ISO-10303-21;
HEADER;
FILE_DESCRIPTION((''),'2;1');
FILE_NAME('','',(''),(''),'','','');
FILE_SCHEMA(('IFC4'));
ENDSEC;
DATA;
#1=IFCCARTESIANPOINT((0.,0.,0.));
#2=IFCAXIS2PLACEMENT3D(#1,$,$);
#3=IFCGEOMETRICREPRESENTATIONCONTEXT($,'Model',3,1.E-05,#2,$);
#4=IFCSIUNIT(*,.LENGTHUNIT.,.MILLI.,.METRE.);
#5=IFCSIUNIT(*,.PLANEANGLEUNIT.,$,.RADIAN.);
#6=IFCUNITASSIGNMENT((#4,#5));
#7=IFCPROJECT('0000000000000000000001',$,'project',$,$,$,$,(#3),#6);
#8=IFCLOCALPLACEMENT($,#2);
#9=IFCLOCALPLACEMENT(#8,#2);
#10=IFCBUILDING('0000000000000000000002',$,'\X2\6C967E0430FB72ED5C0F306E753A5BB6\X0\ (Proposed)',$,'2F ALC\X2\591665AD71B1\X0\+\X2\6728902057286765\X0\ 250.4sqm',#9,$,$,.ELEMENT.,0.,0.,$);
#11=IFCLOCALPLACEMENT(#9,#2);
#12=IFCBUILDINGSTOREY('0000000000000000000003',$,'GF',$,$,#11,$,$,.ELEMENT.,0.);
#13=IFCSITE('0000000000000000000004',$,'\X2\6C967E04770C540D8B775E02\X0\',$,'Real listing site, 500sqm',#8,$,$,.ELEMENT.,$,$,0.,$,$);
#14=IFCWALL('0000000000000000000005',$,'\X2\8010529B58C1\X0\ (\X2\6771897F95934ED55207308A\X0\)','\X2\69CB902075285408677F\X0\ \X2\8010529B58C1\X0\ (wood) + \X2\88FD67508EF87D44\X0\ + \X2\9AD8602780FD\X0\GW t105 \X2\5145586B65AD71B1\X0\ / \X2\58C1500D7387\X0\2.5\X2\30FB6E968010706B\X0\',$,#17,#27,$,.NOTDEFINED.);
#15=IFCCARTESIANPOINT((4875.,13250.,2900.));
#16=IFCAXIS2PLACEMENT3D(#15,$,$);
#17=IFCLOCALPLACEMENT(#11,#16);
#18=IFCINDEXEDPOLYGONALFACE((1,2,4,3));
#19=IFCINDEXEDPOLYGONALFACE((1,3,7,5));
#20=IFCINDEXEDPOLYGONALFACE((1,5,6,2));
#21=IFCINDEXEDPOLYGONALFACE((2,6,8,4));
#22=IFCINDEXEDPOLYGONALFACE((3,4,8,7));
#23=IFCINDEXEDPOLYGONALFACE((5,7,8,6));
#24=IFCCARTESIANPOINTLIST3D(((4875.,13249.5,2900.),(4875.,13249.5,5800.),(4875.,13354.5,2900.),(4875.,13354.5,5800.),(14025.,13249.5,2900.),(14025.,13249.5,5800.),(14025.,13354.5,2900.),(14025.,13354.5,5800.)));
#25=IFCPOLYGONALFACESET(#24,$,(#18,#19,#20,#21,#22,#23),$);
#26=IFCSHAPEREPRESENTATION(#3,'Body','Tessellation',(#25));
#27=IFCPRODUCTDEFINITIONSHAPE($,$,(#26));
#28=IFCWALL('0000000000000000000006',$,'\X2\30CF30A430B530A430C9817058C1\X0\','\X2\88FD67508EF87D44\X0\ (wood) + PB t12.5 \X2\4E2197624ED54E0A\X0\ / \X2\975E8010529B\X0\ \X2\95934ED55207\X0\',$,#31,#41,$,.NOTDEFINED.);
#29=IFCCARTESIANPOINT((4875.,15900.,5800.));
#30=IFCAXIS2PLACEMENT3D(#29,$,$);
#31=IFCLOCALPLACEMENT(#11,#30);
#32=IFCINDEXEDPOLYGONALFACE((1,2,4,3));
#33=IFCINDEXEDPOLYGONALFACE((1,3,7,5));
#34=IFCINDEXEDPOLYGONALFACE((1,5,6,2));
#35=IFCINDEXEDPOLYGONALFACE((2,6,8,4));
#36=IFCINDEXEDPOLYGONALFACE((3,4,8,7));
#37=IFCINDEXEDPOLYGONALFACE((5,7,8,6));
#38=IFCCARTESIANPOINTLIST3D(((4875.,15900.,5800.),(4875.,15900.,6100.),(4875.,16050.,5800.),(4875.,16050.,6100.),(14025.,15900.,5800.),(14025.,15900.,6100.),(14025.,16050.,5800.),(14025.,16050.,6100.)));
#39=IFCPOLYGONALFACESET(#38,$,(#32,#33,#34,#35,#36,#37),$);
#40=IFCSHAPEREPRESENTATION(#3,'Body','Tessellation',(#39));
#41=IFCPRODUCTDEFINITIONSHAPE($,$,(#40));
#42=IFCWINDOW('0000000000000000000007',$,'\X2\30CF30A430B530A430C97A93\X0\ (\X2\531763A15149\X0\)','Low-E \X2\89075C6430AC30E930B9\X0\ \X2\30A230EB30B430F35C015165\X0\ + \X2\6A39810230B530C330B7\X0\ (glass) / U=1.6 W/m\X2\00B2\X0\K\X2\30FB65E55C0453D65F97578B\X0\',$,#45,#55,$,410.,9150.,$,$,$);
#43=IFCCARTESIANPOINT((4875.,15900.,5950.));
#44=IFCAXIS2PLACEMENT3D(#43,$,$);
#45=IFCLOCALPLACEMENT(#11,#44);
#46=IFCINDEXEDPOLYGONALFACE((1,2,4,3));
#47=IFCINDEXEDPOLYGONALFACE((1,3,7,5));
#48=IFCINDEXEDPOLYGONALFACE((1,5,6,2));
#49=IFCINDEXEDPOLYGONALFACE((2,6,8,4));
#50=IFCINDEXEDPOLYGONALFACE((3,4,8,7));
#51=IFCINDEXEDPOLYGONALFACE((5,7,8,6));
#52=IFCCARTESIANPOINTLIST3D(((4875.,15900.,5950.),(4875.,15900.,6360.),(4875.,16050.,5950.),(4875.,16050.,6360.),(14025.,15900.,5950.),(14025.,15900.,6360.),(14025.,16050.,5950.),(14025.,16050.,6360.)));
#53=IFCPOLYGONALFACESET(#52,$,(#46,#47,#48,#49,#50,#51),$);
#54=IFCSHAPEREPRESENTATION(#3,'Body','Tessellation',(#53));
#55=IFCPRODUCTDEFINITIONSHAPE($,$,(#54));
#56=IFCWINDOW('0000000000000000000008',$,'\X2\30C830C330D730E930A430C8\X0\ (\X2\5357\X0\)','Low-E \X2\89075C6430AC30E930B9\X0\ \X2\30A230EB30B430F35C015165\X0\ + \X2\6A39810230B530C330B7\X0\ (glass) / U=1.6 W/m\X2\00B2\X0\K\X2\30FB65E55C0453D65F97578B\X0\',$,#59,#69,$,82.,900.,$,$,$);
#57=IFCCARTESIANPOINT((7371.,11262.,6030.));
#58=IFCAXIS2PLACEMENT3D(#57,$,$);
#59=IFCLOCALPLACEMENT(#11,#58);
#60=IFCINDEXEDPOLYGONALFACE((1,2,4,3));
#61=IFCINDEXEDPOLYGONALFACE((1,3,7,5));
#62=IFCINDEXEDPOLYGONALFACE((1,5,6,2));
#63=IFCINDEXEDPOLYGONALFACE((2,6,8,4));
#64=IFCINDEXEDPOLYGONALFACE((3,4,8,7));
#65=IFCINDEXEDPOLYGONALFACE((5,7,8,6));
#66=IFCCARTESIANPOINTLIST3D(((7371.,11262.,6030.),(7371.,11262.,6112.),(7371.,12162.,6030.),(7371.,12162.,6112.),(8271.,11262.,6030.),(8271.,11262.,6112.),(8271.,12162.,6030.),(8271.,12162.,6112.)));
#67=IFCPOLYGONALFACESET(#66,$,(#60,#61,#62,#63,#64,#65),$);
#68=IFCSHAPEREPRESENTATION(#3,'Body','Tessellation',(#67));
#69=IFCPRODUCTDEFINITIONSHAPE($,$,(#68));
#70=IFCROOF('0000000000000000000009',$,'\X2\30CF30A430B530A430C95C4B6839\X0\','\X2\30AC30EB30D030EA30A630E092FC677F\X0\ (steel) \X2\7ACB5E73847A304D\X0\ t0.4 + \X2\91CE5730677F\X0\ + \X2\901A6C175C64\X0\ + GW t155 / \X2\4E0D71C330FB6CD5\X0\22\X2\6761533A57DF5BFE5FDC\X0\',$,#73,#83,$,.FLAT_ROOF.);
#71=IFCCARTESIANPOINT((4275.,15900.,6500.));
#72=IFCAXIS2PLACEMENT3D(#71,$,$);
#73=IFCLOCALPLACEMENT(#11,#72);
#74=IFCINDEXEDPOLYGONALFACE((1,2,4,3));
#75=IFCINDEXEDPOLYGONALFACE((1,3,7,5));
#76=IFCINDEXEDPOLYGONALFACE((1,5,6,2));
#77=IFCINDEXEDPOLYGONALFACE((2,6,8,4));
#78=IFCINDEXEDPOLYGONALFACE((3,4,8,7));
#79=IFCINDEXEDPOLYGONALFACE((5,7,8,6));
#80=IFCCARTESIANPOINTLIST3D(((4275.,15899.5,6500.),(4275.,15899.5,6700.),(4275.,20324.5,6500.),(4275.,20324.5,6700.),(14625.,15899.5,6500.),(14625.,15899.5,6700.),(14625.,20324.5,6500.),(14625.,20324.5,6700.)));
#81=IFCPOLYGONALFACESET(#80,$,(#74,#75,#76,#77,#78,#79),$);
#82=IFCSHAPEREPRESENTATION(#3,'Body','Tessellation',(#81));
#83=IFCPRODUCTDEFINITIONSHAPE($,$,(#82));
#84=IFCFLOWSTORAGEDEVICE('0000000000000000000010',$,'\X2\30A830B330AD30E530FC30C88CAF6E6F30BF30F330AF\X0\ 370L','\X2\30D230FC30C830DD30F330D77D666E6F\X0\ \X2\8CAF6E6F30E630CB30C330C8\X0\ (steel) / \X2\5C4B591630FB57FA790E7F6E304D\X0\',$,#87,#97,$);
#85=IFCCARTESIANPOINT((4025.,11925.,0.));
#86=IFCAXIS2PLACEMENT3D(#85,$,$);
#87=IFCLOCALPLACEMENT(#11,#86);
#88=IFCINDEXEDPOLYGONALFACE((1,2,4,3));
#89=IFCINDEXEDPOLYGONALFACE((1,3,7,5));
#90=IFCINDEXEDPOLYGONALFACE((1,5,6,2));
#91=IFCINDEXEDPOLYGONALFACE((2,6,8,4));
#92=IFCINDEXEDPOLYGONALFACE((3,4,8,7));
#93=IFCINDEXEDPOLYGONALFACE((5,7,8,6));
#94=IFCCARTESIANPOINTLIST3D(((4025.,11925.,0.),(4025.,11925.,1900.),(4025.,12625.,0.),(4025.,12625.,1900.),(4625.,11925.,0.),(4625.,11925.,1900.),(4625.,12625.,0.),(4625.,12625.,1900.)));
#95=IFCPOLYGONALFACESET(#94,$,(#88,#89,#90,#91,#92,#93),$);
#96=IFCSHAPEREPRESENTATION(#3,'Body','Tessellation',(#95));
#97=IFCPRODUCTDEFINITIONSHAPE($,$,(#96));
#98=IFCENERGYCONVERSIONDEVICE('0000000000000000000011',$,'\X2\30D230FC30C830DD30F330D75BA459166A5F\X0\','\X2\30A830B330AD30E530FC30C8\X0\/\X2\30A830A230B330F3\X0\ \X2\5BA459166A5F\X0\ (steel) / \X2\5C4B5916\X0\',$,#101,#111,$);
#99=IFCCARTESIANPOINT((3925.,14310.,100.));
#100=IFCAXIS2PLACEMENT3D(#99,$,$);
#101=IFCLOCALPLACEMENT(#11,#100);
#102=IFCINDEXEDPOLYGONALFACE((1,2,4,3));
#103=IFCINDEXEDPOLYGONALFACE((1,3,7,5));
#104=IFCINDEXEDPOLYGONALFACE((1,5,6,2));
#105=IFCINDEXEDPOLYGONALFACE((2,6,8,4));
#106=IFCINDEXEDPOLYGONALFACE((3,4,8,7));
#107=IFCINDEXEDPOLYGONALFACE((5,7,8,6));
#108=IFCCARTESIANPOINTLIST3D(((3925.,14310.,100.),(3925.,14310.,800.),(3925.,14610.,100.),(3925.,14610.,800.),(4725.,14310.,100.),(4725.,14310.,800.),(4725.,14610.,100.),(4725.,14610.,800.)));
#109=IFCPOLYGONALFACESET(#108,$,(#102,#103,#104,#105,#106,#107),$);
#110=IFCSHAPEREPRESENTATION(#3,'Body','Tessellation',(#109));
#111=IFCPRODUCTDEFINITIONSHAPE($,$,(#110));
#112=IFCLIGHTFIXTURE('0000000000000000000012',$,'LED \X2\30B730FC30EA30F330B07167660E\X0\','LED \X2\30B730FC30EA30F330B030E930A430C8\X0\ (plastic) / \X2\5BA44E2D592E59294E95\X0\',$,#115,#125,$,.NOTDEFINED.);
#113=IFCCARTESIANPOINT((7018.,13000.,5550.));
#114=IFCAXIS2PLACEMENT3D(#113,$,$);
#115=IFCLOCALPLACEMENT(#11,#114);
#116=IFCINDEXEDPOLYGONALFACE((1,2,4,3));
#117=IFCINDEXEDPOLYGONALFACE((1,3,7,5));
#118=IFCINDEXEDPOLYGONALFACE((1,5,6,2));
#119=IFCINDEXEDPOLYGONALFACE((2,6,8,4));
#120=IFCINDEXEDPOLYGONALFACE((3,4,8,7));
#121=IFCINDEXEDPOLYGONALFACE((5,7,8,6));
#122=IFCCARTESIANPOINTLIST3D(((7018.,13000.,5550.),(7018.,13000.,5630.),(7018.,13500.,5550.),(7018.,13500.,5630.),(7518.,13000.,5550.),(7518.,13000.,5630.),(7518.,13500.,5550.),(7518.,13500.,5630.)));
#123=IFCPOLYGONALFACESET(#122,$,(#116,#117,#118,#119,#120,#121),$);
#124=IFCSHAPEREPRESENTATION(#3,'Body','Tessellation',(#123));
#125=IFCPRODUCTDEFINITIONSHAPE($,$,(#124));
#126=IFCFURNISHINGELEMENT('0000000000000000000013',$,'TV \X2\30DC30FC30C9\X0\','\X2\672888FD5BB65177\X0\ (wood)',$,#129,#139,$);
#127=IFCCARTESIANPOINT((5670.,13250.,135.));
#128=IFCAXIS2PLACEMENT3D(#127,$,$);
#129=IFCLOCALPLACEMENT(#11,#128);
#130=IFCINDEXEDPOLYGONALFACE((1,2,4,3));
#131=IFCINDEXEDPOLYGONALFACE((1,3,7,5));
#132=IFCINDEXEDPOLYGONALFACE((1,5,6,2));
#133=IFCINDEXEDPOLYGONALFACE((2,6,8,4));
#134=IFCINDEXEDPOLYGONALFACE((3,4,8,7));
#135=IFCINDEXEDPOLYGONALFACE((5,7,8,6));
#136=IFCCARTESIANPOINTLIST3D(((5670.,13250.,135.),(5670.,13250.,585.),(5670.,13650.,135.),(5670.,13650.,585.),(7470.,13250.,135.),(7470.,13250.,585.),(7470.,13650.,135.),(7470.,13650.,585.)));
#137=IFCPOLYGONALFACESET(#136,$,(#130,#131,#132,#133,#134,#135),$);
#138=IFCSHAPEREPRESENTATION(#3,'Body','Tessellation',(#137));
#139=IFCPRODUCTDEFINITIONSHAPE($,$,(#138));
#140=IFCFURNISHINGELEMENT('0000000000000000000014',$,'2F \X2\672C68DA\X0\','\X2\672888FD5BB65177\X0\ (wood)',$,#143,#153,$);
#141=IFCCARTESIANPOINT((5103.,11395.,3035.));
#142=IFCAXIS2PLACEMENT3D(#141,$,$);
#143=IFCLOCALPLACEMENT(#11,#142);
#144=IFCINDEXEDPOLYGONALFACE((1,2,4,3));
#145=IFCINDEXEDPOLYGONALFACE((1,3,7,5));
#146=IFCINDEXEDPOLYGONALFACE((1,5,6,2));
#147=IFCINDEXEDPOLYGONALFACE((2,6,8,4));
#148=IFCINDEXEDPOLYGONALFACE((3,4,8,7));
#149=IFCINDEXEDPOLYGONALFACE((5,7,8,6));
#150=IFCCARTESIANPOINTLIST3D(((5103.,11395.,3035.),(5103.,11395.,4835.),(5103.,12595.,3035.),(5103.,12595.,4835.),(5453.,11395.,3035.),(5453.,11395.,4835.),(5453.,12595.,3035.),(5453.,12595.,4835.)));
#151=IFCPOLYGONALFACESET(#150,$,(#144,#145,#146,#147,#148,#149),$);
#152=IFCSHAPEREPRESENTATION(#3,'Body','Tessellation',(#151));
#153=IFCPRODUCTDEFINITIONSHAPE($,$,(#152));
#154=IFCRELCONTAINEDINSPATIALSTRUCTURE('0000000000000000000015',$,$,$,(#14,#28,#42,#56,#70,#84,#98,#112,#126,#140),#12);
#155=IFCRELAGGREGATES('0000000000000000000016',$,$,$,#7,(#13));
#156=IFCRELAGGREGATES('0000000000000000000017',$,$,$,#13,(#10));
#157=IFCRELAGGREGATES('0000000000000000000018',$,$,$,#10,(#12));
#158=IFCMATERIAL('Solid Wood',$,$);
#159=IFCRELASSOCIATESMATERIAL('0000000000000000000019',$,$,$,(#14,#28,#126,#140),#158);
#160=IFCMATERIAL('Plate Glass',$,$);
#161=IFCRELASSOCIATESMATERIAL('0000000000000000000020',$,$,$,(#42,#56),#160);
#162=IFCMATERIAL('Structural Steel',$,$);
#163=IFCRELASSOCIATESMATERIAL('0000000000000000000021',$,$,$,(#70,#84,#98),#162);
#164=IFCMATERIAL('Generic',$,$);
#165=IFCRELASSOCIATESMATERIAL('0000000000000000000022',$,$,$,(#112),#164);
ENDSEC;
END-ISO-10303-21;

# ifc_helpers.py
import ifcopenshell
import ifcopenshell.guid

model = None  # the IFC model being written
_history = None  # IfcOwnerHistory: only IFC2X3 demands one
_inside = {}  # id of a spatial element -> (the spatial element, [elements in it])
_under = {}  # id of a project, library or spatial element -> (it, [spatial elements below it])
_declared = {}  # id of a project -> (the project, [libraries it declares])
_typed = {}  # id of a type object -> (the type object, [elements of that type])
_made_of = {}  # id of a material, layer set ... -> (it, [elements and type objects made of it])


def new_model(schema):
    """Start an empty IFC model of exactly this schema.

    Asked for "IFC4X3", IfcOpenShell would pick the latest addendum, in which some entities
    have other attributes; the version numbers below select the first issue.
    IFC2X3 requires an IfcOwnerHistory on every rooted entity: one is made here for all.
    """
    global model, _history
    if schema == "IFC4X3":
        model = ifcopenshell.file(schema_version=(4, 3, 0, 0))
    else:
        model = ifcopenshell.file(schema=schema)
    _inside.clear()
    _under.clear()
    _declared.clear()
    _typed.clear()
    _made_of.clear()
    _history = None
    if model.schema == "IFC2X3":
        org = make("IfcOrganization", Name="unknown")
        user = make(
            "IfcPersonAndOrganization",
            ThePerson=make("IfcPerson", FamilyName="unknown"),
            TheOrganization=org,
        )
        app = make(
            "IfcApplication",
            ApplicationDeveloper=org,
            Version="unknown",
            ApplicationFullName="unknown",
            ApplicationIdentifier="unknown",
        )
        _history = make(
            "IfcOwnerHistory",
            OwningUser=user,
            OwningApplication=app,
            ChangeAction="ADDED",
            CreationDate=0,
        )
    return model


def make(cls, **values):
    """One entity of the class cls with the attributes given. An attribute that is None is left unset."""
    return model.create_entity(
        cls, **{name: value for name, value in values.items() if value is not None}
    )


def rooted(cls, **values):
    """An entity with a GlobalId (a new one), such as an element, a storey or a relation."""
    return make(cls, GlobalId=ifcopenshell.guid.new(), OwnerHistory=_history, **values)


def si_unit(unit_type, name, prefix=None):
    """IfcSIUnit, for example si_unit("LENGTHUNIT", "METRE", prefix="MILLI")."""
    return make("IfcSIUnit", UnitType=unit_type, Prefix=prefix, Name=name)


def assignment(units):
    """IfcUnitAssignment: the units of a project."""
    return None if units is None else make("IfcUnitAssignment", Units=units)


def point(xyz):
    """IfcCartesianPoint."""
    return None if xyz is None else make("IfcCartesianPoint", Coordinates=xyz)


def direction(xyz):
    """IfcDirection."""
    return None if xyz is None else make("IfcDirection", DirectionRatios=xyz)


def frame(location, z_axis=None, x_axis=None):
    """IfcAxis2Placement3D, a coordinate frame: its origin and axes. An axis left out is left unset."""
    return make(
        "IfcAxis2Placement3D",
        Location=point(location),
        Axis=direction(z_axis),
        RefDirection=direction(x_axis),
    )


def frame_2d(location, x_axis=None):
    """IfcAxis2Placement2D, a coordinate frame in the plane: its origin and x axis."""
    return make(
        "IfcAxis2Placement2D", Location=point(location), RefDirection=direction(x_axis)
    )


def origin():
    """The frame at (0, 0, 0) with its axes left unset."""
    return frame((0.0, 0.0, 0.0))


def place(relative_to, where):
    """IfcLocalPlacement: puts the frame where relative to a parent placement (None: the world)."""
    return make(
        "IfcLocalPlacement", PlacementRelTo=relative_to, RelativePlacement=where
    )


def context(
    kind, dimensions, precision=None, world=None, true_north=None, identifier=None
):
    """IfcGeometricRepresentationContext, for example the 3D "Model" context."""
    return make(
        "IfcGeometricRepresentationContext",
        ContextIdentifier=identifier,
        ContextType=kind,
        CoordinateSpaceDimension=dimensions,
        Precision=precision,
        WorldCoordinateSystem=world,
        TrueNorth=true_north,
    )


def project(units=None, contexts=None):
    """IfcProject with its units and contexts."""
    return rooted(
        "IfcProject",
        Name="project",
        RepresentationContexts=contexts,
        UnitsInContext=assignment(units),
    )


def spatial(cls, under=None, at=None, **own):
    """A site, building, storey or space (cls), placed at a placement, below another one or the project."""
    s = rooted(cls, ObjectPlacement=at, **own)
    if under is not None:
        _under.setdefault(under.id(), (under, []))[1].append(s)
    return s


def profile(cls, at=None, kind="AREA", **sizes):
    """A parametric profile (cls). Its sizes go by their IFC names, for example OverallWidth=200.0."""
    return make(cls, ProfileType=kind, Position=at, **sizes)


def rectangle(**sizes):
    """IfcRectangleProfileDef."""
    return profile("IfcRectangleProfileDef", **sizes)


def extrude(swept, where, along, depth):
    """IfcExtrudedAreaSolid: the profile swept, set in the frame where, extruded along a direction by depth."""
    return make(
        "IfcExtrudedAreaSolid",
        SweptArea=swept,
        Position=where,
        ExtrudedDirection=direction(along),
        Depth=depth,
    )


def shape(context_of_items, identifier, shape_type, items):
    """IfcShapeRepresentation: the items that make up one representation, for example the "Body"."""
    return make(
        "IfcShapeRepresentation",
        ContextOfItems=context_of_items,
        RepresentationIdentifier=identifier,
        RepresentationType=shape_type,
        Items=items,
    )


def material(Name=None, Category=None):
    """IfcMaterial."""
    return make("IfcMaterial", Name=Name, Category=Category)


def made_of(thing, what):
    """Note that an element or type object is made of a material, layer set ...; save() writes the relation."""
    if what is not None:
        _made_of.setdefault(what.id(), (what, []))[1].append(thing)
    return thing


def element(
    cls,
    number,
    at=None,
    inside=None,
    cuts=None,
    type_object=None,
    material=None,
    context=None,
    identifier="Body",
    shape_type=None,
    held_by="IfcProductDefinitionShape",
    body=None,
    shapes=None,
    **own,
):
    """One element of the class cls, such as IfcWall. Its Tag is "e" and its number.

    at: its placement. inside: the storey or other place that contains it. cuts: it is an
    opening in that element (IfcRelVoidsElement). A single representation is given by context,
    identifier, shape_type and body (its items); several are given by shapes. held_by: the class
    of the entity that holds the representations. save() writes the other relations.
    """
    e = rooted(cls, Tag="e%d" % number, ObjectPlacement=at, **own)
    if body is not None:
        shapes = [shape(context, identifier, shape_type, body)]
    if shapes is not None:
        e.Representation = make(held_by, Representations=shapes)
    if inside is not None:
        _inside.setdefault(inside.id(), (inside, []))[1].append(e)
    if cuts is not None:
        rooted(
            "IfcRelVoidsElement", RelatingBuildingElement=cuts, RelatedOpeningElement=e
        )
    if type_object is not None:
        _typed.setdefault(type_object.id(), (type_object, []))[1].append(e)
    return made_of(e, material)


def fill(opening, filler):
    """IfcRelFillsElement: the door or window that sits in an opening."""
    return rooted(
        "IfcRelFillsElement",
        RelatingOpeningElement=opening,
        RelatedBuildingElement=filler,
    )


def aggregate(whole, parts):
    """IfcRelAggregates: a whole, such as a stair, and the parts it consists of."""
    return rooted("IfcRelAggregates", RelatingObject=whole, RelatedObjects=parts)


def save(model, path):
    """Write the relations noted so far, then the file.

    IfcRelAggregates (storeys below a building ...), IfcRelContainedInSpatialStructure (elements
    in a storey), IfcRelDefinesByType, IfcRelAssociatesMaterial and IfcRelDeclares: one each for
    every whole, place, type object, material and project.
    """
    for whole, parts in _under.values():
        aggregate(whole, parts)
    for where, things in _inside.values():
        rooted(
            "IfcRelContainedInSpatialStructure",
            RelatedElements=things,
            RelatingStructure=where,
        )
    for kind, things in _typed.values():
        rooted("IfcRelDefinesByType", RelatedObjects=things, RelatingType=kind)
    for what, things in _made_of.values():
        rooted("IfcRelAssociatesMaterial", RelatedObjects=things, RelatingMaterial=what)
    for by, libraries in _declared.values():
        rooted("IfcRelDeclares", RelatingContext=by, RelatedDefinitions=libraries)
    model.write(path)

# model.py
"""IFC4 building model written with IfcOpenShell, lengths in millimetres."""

from ifc_helpers import new_model, si_unit, frame, frame_2d, origin, place, context, project, spatial, rectangle, extrude, material, element, fill, save


model = new_model("IFC4")

# Units and contexts
model_context = context("Model", 3, precision=1e-05, world=origin())
ifc_project = project(units=[si_unit("LENGTHUNIT", "METRE", prefix="MILLI"), si_unit("PLANEANGLEUNIT", "RADIAN")], contexts=[model_context])

# Site, building, storey
site_placement = place(None, origin())
site = spatial("IfcSite", under=ifc_project, at=site_placement, Name="沖縄県名護市", ObjectType="Real listing site, 500sqm", CompositionType="ELEMENT", RefElevation=0.0)
building_placement = place(site_placement, origin())
building = spatial("IfcBuilding", under=site, at=building_placement, Name="沖縄・狭小の町家 (Proposed)", ObjectType="2F ALC外断熱+木造在来 250.4sqm", CompositionType="ELEMENT", ElevationOfRefHeight=0.0, ElevationOfTerrain=0.0)
storey_placement = place(building_placement, origin())
storey = spatial("IfcBuildingStorey", under=building, at=storey_placement, Name="GF", CompositionType="ELEMENT", Elevation=0.0)

# Shared definitions
ifc_material_1 = material(Name="Solid Wood")

# Wall
wall_1_placement = place(storey_placement, frame((4875.0, 13250.0, 2900.0)))
element("IfcWall", 1, at=wall_1_placement, inside=storey, material=ifc_material_1, Name="耐力壁 (東西間仕切り)", Description="構造用合板 耐力壁 (wood) + 製材軸組 + 高性能GW t105 充填断熱 / 壁倍率2.5・準耐火", PredefinedType="NOTDEFINED", context=model_context, shape_type="SweptSolid", body=[
    extrude(rectangle(XDim=9150.0, YDim=105.0, at=frame_2d((4575.0, 52.0))), frame((4875.0, 13250.0, 2900.0)), (0.0, 0.0, 1.0), 2900.0),
])

# Wall, opening, window
wall_2_placement = place(storey_placement, frame((4875.0, 15900.0, 5800.0)))
wall_2 = element("IfcWall", 2, at=wall_2_placement, inside=storey, material=ifc_material_1, Name="ハイサイド腰壁", Description="製材軸組 (wood) + PB t12.5 両面仕上 / 非耐力 間仕切", PredefinedType="NOTDEFINED", context=model_context, shape_type="SweptSolid", body=[
    extrude(rectangle(XDim=9150.0, YDim=150.0, at=frame_2d((4575.0, 75.0))), frame((4875.0, 15900.0, 5800.0)), (0.0, 0.0, 1.0), 700.0),
])
opening_1_placement = place(storey_placement, frame((4875.0, 15900.0, 5950.0)))
opening_1 = element("IfcOpeningElement", 3, at=opening_1_placement, cuts=wall_2, PredefinedType="NOTDEFINED", context=model_context, shape_type="SweptSolid", body=[
    extrude(rectangle(XDim=9150.0, YDim=150.0, at=frame_2d((4575.0, 75.0))), frame((4875.0, 15900.0, 5950.0)), (0.0, 0.0, 1.0), 410.0),
])
ifc_material_2 = material(Name="Plate Glass")
window_1_placement = place(storey_placement, frame((4875.0, 15900.0, 5950.0)))
window_1 = element("IfcWindow", 4, at=window_1_placement, inside=storey, material=ifc_material_2, Name="ハイサイド窓 (北採光)", Description="Low-E 複層ガラス アルゴン封入 + 樹脂サッシ (glass) / U=1.6 W/m²K・日射取得型", OverallHeight=410.0, OverallWidth=9150.0, context=model_context, shape_type="SweptSolid", body=[
    extrude(rectangle(XDim=9150.0, YDim=150.0, at=frame_2d((4575.0, 75.0))), frame((4875.0, 15900.0, 5950.0)), (0.0, 0.0, 1.0), 410.0),
])
fill(opening_1, window_1)

# Window
window_2_placement = place(storey_placement, frame((7371.0, 11262.0, 6030.0)))
element("IfcWindow", 5, at=window_2_placement, inside=storey, material=ifc_material_2, Name="トップライト (南)", Description="Low-E 複層ガラス アルゴン封入 + 樹脂サッシ (glass) / U=1.6 W/m²K・日射取得型", OverallHeight=82.0, OverallWidth=900.0, context=model_context, shape_type="SweptSolid", body=[
    extrude(rectangle(XDim=900.0, YDim=900.0, at=frame_2d((450.0, 450.0))), frame((7371.0, 11262.0, 6030.0)), (0.0, 0.0, 1.0), 82.0),
])

# Roof
ifc_material_3 = material(Name="Structural Steel")
roof_placement = place(storey_placement, frame((4275.0, 15900.0, 6500.0)))
element("IfcRoof", 6, at=roof_placement, inside=storey, material=ifc_material_3, Name="ハイサイド屋根", Description="ガルバリウム鋼板 (steel) 立平葺き t0.4 + 野地板 + 通気層 + GW t155 / 不燃・法22条区域対応", PredefinedType="FLAT_ROOF", context=model_context, shape_type="SweptSolid", body=[
    extrude(rectangle(XDim=10350.0, YDim=4425.0, at=frame_2d((5175.0, 2212.0))), frame((4275.0, 15900.0, 6500.0)), (0.0, 0.0, 1.0), 200.0),
])

# Flow storage device
flow_storage_device_placement = place(storey_placement, frame((4025.0, 11925.0, 0.0)))
element("IfcFlowStorageDevice", 7, at=flow_storage_device_placement, inside=storey, material=ifc_material_3, Name="エコキュート貯湯タンク 370L", Description="ヒートポンプ給湯 貯湯ユニット (steel) / 屋外・基礎置き", context=model_context, shape_type="SweptSolid", body=[
    extrude(rectangle(XDim=600.0, YDim=700.0, at=frame_2d((300.0, 350.0))), frame((4025.0, 11925.0, 0.0)), (0.0, 0.0, 1.0), 1900.0),
])

# Energy conversion device
energy_conversion_device_placement = place(storey_placement, frame((3925.0, 14310.0, 100.0)))
element("IfcEnergyConversionDevice", 8, at=energy_conversion_device_placement, inside=storey, material=ifc_material_3, Name="ヒートポンプ室外機", Description="エコキュート/エアコン 室外機 (steel) / 屋外", context=model_context, shape_type="SweptSolid", body=[
    extrude(rectangle(XDim=800.0, YDim=300.0, at=frame_2d((400.0, 150.0))), frame((3925.0, 14310.0, 100.0)), (0.0, 0.0, 1.0), 700.0),
])

# Light fixture
ifc_material_4 = material(Name="Generic")
light_fixture_placement = place(storey_placement, frame((7018.0, 13000.0, 5550.0)))
element("IfcLightFixture", 9, at=light_fixture_placement, inside=storey, material=ifc_material_4, Name="LED シーリング照明", Description="LED シーリングライト (plastic) / 室中央天井", PredefinedType="NOTDEFINED", context=model_context, shape_type="SweptSolid", body=[
    extrude(rectangle(XDim=500.0, YDim=500.0, at=frame_2d((250.0, 250.0))), frame((7018.0, 13000.0, 5550.0)), (0.0, 0.0, 1.0), 80.0),
])

# Furnishing elements
furnishing_1_placement = place(storey_placement, frame((5670.0, 13250.0, 135.0)))
element("IfcFurnishingElement", 10, at=furnishing_1_placement, inside=storey, material=ifc_material_1, Name="TV ボード", Description="木製家具 (wood)", context=model_context, shape_type="SweptSolid", body=[
    extrude(rectangle(XDim=1800.0, YDim=400.0, at=frame_2d((900.0, 200.0))), frame((5670.0, 13250.0, 135.0)), (0.0, 0.0, 1.0), 450.0),
])
furnishing_2_placement = place(storey_placement, frame((5103.0, 11395.0, 3035.0)))
element("IfcFurnishingElement", 11, at=furnishing_2_placement, inside=storey, material=ifc_material_1, Name="2F 本棚", Description="木製家具 (wood)", context=model_context, shape_type="SweptSolid", body=[
    extrude(rectangle(XDim=350.0, YDim=1200.0, at=frame_2d((175.0, 600.0))), frame((5103.0, 11395.0, 3035.0)), (0.0, 0.0, 1.0), 1800.0),
])

save(model, "model.ifc")
